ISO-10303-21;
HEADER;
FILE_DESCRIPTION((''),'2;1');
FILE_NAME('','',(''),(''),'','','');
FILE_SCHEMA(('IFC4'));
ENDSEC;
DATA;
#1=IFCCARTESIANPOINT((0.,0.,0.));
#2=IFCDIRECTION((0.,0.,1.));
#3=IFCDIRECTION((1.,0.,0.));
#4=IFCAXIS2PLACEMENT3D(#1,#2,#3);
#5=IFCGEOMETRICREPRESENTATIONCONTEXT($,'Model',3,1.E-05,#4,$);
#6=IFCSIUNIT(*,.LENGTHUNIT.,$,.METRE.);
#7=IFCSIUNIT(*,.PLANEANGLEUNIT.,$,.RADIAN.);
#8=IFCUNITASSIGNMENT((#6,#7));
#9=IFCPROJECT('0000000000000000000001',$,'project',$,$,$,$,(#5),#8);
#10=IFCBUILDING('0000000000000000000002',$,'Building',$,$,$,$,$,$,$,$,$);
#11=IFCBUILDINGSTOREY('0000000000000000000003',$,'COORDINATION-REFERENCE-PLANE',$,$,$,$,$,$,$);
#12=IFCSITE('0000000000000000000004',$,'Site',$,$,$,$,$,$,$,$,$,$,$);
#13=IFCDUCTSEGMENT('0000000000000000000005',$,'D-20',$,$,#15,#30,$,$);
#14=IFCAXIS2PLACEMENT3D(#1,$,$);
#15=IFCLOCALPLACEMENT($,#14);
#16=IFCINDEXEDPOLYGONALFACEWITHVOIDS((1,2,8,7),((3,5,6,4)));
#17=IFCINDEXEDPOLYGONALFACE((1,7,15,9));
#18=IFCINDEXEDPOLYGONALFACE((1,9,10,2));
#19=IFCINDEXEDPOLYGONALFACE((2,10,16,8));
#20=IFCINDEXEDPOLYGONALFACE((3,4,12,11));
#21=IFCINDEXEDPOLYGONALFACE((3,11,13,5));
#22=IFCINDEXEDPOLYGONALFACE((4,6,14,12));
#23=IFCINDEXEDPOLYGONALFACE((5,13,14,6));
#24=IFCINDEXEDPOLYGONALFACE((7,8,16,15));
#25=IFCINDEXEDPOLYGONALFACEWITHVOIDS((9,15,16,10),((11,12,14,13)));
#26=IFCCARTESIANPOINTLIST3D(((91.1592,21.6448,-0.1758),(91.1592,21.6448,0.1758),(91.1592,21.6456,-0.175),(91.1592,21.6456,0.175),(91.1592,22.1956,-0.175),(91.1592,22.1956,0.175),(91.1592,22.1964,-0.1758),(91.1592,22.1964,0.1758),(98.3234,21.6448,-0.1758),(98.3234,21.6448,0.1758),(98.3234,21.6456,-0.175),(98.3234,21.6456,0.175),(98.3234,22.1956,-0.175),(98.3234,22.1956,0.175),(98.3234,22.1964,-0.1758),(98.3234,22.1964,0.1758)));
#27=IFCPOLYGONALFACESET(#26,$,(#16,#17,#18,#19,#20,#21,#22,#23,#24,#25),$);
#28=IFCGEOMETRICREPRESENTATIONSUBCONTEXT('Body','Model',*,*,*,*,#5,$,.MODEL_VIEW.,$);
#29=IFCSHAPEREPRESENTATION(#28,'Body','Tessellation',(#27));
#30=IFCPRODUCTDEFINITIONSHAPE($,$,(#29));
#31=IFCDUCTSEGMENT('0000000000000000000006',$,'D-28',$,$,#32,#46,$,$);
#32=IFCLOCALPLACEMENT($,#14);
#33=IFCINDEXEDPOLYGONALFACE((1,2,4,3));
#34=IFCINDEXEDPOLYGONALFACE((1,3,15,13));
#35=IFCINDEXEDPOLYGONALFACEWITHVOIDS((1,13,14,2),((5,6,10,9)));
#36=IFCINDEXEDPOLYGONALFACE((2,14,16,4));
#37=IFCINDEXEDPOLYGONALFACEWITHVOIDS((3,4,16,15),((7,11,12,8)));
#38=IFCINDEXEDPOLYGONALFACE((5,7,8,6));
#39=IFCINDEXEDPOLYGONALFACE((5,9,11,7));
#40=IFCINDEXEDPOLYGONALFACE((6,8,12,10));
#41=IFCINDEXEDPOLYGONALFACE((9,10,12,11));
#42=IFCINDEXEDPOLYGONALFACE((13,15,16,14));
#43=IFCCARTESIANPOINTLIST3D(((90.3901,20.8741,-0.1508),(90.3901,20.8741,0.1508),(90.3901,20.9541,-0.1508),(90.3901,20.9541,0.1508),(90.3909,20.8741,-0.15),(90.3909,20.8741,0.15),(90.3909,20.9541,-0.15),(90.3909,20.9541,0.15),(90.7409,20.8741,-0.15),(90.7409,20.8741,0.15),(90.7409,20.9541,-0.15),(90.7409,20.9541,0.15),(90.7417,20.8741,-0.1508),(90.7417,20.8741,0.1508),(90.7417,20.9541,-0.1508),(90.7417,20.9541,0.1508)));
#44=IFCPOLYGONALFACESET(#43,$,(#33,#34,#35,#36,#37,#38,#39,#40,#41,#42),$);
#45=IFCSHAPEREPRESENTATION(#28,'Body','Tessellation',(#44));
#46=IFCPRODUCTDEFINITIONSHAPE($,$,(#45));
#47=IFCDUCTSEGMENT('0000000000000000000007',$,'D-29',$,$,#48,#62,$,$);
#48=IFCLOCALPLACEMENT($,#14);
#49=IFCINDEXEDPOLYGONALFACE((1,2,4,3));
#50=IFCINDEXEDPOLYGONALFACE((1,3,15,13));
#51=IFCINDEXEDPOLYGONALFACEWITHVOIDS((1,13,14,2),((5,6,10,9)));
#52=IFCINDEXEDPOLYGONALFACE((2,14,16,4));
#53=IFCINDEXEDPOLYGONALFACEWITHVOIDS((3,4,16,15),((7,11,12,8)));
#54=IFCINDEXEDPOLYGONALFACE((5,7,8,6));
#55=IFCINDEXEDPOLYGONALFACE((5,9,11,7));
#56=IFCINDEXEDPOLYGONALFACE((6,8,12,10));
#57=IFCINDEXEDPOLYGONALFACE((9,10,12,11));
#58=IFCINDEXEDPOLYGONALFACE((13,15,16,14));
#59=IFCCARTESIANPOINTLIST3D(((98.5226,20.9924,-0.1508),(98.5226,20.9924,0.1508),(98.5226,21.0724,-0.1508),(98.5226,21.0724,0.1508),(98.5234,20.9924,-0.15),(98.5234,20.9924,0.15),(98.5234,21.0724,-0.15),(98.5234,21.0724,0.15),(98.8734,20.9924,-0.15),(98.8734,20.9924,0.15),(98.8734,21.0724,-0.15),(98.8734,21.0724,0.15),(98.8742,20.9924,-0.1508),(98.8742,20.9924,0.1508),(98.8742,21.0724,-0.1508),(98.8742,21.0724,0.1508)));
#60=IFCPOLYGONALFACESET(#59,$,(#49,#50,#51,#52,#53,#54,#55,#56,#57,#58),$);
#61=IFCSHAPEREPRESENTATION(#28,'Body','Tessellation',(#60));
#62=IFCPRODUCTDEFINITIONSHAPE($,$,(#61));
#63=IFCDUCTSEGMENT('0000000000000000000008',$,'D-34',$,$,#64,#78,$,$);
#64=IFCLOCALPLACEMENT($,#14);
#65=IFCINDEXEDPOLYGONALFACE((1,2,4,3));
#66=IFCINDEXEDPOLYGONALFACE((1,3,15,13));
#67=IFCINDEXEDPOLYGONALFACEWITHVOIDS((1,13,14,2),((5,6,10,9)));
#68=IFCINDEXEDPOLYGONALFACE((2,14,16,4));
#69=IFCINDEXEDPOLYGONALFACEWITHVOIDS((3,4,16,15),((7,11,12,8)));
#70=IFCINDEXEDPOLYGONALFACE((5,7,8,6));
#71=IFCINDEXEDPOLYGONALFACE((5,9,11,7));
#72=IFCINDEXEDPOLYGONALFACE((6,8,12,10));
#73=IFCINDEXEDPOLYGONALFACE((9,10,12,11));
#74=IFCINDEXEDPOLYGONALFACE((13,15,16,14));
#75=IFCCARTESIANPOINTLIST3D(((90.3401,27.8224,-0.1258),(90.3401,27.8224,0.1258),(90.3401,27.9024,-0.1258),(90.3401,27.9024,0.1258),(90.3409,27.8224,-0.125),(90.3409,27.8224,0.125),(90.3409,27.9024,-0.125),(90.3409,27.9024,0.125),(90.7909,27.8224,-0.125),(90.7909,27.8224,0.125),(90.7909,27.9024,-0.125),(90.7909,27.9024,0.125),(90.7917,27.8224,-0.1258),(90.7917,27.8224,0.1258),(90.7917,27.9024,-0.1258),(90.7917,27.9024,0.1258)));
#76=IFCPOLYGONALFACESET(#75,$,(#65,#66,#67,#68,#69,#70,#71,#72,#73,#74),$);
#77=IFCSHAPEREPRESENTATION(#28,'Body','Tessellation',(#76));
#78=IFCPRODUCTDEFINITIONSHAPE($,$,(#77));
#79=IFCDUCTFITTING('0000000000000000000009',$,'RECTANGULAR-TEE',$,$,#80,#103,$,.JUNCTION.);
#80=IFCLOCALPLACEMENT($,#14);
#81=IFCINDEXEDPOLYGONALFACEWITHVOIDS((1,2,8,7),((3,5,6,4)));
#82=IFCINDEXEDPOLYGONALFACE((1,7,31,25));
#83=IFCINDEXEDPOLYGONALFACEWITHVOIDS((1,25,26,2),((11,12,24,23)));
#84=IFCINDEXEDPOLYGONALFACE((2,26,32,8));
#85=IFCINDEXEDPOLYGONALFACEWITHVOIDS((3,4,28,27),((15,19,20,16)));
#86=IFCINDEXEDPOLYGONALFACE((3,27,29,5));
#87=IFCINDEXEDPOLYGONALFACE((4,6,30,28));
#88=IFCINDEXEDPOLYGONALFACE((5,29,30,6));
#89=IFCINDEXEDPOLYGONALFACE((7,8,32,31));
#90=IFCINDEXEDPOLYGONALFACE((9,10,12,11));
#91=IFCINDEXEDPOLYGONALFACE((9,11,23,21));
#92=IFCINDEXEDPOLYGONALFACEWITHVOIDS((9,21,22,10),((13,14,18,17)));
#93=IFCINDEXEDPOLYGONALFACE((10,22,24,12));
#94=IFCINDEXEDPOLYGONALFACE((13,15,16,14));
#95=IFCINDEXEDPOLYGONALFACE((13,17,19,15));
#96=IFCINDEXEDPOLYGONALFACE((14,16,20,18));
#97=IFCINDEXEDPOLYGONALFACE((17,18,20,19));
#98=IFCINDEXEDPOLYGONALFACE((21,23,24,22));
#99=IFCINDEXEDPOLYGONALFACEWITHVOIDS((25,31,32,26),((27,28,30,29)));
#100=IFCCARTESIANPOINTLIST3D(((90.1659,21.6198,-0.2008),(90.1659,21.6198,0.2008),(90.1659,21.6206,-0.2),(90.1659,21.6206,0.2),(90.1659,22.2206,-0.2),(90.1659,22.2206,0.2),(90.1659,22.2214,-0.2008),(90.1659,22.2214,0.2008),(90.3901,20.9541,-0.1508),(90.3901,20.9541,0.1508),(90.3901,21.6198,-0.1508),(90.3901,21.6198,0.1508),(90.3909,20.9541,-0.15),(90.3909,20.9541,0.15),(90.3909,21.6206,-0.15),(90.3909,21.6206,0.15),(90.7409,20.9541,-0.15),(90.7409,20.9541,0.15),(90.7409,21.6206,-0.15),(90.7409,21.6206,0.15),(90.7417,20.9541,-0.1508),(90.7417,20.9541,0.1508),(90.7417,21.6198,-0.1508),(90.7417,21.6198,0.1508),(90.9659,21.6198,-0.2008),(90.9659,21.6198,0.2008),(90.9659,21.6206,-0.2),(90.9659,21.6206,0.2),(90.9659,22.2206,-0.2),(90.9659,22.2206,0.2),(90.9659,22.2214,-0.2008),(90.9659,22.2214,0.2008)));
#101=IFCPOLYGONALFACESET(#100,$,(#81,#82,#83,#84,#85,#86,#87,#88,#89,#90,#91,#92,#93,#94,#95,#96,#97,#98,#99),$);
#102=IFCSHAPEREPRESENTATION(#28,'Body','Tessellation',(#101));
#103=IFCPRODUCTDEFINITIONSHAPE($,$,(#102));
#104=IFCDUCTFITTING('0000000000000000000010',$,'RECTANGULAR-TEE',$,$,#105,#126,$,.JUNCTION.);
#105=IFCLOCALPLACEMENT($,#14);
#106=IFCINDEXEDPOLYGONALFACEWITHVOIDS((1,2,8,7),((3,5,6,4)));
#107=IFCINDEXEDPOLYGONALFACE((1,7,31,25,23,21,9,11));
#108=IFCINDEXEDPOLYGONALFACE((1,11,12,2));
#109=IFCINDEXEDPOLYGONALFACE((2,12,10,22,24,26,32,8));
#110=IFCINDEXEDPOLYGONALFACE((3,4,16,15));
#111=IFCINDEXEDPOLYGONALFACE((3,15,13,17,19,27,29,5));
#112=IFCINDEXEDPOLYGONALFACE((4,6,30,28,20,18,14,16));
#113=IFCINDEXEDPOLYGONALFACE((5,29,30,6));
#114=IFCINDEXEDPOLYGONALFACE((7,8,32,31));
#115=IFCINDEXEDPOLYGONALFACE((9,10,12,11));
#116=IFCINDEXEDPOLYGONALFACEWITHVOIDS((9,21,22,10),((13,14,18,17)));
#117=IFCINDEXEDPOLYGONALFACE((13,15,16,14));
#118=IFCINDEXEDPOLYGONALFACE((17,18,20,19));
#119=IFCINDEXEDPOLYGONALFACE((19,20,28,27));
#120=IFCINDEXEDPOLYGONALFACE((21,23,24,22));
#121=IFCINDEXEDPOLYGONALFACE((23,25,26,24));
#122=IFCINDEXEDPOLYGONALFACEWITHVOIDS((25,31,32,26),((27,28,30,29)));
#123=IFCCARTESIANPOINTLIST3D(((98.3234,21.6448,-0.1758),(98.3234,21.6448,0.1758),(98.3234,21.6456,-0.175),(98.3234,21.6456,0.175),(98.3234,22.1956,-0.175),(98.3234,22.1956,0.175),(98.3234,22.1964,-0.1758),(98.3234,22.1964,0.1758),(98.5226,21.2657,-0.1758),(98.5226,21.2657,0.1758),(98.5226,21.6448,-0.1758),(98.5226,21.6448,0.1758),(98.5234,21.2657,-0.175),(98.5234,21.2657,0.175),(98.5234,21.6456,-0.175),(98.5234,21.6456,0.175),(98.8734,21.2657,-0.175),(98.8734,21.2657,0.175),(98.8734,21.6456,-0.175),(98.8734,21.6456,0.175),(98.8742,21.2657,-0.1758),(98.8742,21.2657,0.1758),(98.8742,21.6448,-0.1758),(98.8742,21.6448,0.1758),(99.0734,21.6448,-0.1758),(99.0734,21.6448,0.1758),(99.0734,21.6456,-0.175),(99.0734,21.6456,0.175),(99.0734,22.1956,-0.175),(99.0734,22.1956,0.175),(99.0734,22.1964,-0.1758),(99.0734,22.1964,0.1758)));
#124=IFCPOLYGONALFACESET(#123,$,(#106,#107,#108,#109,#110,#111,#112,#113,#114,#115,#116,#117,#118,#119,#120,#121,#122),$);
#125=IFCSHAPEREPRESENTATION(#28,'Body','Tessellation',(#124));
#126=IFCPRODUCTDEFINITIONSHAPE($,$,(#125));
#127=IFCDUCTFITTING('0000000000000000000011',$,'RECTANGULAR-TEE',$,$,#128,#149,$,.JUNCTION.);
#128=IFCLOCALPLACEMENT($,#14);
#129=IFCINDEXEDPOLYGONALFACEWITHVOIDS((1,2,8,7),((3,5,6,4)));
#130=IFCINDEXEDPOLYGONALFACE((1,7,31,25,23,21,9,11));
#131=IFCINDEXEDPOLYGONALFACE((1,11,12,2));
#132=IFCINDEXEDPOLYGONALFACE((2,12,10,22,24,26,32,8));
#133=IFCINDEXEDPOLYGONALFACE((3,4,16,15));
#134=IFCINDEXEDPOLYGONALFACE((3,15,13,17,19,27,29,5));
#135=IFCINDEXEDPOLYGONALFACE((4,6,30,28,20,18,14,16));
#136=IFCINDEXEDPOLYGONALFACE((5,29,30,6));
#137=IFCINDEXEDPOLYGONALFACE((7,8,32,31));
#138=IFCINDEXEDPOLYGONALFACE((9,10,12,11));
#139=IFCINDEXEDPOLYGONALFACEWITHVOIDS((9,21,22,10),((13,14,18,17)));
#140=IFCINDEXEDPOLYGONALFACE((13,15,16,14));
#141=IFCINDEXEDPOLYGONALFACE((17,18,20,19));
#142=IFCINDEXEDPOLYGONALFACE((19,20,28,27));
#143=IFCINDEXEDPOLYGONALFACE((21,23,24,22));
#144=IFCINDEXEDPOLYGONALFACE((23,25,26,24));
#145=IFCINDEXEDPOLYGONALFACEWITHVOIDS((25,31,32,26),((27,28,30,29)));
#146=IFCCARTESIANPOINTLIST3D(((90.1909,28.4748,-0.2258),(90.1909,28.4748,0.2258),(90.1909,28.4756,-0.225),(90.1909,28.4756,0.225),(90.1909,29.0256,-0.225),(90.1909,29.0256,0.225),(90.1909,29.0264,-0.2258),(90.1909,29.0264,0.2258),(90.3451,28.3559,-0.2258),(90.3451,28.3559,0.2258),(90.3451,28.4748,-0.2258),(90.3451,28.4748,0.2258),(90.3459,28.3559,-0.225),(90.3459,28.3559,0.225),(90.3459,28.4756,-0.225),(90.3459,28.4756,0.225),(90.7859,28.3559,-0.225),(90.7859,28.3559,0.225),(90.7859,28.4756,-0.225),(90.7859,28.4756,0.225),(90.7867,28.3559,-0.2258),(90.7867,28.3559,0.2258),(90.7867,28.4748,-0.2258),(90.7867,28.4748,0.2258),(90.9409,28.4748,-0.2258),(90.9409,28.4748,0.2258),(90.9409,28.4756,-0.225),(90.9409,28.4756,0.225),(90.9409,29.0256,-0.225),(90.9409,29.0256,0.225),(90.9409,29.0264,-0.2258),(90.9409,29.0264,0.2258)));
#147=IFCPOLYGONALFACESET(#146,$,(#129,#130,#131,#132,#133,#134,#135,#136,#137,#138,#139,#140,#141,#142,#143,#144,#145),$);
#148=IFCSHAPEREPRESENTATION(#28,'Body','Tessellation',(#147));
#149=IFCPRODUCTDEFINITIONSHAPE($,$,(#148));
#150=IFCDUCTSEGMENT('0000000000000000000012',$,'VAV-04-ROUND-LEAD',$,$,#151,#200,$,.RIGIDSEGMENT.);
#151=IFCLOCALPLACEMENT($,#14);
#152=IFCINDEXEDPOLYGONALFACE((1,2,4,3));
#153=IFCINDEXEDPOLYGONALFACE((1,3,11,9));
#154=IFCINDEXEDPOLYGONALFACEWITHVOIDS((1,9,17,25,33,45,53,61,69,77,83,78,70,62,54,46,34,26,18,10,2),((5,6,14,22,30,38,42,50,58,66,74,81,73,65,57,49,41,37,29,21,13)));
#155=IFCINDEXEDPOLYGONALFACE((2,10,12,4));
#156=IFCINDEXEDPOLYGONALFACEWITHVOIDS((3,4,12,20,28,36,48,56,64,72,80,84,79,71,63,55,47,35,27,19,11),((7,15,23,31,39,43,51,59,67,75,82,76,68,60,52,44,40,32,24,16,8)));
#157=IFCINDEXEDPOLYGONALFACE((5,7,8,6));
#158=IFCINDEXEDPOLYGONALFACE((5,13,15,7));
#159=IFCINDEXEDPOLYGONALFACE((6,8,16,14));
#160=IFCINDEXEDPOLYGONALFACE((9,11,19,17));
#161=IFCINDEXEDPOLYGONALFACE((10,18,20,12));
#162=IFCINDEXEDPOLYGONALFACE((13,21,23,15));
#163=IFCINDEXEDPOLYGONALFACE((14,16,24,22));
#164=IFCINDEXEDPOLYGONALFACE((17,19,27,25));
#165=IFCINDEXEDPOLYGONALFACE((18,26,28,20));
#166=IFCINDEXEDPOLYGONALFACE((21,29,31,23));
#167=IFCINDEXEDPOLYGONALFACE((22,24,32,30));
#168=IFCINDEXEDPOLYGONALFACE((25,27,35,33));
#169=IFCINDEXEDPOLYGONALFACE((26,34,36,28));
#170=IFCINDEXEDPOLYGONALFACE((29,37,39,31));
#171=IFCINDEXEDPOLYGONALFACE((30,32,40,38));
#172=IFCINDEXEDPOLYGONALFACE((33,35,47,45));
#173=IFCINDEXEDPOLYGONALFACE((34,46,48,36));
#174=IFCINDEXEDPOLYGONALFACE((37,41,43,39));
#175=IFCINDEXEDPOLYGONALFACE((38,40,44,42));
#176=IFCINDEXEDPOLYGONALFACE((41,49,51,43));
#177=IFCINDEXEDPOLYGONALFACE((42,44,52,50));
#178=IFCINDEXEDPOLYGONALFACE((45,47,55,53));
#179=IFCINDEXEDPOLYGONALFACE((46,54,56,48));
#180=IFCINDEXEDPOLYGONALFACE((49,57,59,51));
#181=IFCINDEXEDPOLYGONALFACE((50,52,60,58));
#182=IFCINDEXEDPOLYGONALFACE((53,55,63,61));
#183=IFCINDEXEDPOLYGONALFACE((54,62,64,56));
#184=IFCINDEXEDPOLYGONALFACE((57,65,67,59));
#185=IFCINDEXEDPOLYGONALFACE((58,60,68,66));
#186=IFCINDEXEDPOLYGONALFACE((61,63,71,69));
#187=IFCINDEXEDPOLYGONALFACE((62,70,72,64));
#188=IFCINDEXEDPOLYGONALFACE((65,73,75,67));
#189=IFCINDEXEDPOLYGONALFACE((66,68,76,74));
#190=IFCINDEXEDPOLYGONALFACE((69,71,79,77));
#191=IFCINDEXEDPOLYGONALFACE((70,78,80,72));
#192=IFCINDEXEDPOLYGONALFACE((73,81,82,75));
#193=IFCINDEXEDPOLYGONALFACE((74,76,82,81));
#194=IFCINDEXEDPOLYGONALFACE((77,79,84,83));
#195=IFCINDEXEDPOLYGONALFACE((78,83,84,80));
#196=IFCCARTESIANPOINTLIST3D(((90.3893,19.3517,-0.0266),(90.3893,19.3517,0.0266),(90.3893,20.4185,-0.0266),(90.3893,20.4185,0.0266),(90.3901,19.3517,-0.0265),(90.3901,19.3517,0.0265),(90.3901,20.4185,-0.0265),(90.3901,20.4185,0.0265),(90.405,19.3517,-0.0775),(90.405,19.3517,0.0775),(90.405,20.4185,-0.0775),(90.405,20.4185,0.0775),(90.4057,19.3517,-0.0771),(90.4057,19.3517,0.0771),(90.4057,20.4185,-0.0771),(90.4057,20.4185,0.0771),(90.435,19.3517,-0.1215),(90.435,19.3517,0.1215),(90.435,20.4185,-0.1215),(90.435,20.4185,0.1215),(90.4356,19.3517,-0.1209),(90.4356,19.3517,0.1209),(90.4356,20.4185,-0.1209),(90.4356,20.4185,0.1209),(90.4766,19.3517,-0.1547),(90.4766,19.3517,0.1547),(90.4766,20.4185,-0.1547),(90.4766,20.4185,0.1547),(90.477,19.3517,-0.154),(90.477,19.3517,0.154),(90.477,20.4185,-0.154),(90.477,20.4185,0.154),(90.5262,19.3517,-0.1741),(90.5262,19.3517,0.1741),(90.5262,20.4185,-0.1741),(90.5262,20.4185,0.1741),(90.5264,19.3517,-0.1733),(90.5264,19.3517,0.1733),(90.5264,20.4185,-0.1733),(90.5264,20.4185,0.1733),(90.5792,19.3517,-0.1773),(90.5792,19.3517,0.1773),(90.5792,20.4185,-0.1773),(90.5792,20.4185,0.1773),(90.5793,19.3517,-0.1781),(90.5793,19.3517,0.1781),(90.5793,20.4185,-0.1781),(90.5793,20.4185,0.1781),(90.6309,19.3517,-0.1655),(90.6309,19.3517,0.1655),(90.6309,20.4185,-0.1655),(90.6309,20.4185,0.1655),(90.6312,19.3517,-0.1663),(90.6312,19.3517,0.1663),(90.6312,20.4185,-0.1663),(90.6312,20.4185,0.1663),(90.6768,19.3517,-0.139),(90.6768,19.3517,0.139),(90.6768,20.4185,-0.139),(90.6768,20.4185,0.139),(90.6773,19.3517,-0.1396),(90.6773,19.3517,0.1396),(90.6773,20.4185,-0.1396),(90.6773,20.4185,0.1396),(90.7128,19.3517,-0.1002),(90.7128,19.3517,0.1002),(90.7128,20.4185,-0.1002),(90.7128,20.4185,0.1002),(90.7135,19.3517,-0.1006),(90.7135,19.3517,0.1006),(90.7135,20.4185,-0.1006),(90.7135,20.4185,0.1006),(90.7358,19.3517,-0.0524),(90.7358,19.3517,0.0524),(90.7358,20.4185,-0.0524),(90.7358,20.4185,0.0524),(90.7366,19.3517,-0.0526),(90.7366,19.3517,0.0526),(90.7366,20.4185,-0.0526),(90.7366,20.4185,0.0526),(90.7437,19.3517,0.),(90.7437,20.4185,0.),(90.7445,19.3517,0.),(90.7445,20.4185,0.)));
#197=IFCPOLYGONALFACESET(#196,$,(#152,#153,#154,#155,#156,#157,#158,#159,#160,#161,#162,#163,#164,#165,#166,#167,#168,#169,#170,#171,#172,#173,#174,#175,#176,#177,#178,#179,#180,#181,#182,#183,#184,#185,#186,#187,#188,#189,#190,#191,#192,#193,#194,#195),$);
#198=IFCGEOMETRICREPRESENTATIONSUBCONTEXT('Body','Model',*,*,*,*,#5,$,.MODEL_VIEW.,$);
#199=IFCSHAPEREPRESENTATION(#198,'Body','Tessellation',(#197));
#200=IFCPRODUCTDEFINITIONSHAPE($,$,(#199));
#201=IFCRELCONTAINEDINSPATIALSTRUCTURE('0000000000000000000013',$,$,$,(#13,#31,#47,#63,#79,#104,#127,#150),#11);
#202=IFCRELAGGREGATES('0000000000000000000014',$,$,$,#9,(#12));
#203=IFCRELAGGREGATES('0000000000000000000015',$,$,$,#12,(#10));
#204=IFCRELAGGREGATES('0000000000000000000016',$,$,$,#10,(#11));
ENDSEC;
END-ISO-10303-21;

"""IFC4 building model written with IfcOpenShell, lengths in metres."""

from ifc_helpers import new_model, si_unit, frame, origin, origin_with_axes, place, context, subcontext, project, spatial, rectangle, hollow_rectangle, hollow_circle, extrude, boolean, element, save


model = new_model("IFC4")

# Units and contexts
model_context = context("Model", 3, precision=1e-05, world=origin_with_axes())
body_context_1 = subcontext(model_context, "Body", "Model", "MODEL_VIEW")
body_context_2 = subcontext(model_context, "Body", "Model", "MODEL_VIEW")
ifc_project = project(units=[si_unit("LENGTHUNIT", "METRE"), si_unit("PLANEANGLEUNIT", "RADIAN")], contexts=[model_context])

# Site, building, storey
site = spatial("IfcSite", under=ifc_project, Name="Site")
building = spatial("IfcBuilding", under=site, Name="Building")
storey = spatial("IfcBuildingStorey", under=building, Name="COORDINATION-REFERENCE-PLANE")

# Duct segments
duct_segment_1_placement = place(None, frame((91.1592, 21.9206, 0.0), z_axis=(1.0, 0.0, 0.0), x_axis=(0.0, 1.0, 0.0)))
element("IfcDuctSegment", 1, at=duct_segment_1_placement, inside=storey, Name="D-20", context=body_context_1, shape_type="SweptSolid", body=[
    extrude(hollow_rectangle(XDim=0.5516, YDim=0.3516, WallThickness=0.0008), origin(), (0.0, 0.0, 1.0), 7.1642),
])
for number, where, z_axis, x_axis, name in (
    (2, (90.5659, 20.8741, 0.0), (0.0, 1.0, 0.0), (1.0, 0.0, 0.0), "D-28"),
    (3, (98.6984, 20.9924, 0.0), (0.0, 1.0, 0.0), (1.0, 0.0, 0.0), "D-29"),
):
    element("IfcDuctSegment", number, at=place(None, frame(where, z_axis=z_axis, x_axis=x_axis)), inside=storey, Name=name, context=body_context_1, shape_type="SweptSolid", body=[
        extrude(hollow_rectangle(XDim=0.3516, YDim=0.3016, WallThickness=0.0008), origin(), (0.0, 0.0, 1.0), 0.08),
    ])
duct_segment_2_placement = place(None, frame((90.5659, 27.8224, 0.0), z_axis=(0.0, 1.0, 0.0), x_axis=(1.0, 0.0, 0.0)))
element("IfcDuctSegment", 4, at=duct_segment_2_placement, inside=storey, Name="D-34", context=body_context_1, shape_type="SweptSolid", body=[
    extrude(hollow_rectangle(XDim=0.4516, YDim=0.2516, WallThickness=0.0008), origin(), (0.0, 0.0, 1.0), 0.08),
])

# Duct fittings
duct_fitting_1_placement = place(None, frame((90.5659, 21.9206, 0.0), z_axis=(1.0, 0.0, 0.0), x_axis=(0.0, -1.0, 0.0)))
solid_1 = boolean("UNION", extrude(rectangle(XDim=0.6, YDim=0.4), frame((0.0, 0.0, -0.4), z_axis=(0.0, 0.0, 1.0), x_axis=(1.0, 0.0, 0.0)), (0.0, 0.0, 1.0), 0.8), extrude(rectangle(XDim=0.35, YDim=0.3), frame((0.0, 0.0, 0.0), z_axis=(1.0, 0.0, 0.0), x_axis=(0.0, 0.0, -1.0)), (0.0, 0.0, 1.0), 0.9665))
element("IfcDuctFitting", 5, at=duct_fitting_1_placement, inside=storey, Name="RECTANGULAR-TEE", PredefinedType="JUNCTION", context=body_context_1, shape_type="CSG", body=[
    boolean("DIFFERENCE", boolean("UNION", extrude(rectangle(XDim=0.6016, YDim=0.4016), frame((0.0, 0.0, -0.4), z_axis=(0.0, 0.0, 1.0), x_axis=(1.0, 0.0, 0.0)), (0.0, 0.0, 1.0), 0.8), extrude(rectangle(XDim=0.3516, YDim=0.3016), frame((0.0, 0.0, 0.0), z_axis=(1.0, 0.0, 0.0), x_axis=(0.0, 0.0, -1.0)), (0.0, 0.0, 1.0), 0.9665)), solid_1),
])
duct_fitting_2_placement = place(None, frame((98.6984, 21.9206, 0.0), z_axis=(1.0, 0.0, 0.0), x_axis=(0.0, -1.0, 0.0)))
solid_2 = boolean("UNION", extrude(rectangle(XDim=0.55, YDim=0.35), frame((0.0, 0.0, -0.375), z_axis=(0.0, 0.0, 1.0), x_axis=(1.0, 0.0, 0.0)), (0.0, 0.0, 1.0), 0.75), extrude(rectangle(XDim=0.35, YDim=0.35), frame((0.0, 0.0, 0.0), z_axis=(1.0, 0.0, 0.0), x_axis=(0.0, 0.0, -1.0)), (0.0, 0.0, 1.0), 0.6549))
element("IfcDuctFitting", 6, at=duct_fitting_2_placement, inside=storey, Name="RECTANGULAR-TEE", PredefinedType="JUNCTION", context=body_context_1, shape_type="CSG", body=[
    boolean("DIFFERENCE", boolean("UNION", extrude(rectangle(XDim=0.5516, YDim=0.3516), frame((0.0, 0.0, -0.375), z_axis=(0.0, 0.0, 1.0), x_axis=(1.0, 0.0, 0.0)), (0.0, 0.0, 1.0), 0.75), extrude(rectangle(XDim=0.3516, YDim=0.3516), frame((0.0, 0.0, 0.0), z_axis=(1.0, 0.0, 0.0), x_axis=(0.0, 0.0, -1.0)), (0.0, 0.0, 1.0), 0.6549)), solid_2),
])
duct_fitting_3_placement = place(None, frame((90.5659, 28.7506, 0.0), z_axis=(1.0, 0.0, 0.0), x_axis=(0.0, -1.0, 0.0)))
solid_3 = boolean("UNION", extrude(rectangle(XDim=0.55, YDim=0.45), frame((0.0, 0.0, -0.375), z_axis=(0.0, 0.0, 1.0), x_axis=(1.0, 0.0, 0.0)), (0.0, 0.0, 1.0), 0.75), extrude(rectangle(XDim=0.44, YDim=0.45), frame((0.0, 0.0, 0.0), z_axis=(1.0, 0.0, 0.0), x_axis=(0.0, 0.0, -1.0)), (0.0, 0.0, 1.0), 0.3947))
element("IfcDuctFitting", 7, at=duct_fitting_3_placement, inside=storey, Name="RECTANGULAR-TEE", PredefinedType="JUNCTION", context=body_context_1, shape_type="CSG", body=[
    boolean("DIFFERENCE", boolean("UNION", extrude(rectangle(XDim=0.5516, YDim=0.4516), frame((0.0, 0.0, -0.375), z_axis=(0.0, 0.0, 1.0), x_axis=(1.0, 0.0, 0.0)), (0.0, 0.0, 1.0), 0.75), extrude(rectangle(XDim=0.4416, YDim=0.4516), frame((0.0, 0.0, 0.0), z_axis=(1.0, 0.0, 0.0), x_axis=(0.0, 0.0, -1.0)), (0.0, 0.0, 1.0), 0.3947)), solid_3),
])

# Duct segment
for number, where, z_axis, x_axis, name in (
    (8, (90.5659, 20.4185, 0.0), (0.0, -1.0, 0.0), (1.0, 0.0, 0.0), "VAV-04-ROUND-LEAD"),
):
    element("IfcDuctSegment", number, at=place(None, frame(where, z_axis=z_axis, x_axis=x_axis)), inside=storey, Name=name, PredefinedType="RIGIDSEGMENT", context=body_context_2, shape_type="SweptSolid", body=[
        extrude(hollow_circle(Radius=0.1786, WallThickness=0.0008), origin(), (0.0, 0.0, 1.0), 1.0668),
    ])

save(model, "model.ifc")
